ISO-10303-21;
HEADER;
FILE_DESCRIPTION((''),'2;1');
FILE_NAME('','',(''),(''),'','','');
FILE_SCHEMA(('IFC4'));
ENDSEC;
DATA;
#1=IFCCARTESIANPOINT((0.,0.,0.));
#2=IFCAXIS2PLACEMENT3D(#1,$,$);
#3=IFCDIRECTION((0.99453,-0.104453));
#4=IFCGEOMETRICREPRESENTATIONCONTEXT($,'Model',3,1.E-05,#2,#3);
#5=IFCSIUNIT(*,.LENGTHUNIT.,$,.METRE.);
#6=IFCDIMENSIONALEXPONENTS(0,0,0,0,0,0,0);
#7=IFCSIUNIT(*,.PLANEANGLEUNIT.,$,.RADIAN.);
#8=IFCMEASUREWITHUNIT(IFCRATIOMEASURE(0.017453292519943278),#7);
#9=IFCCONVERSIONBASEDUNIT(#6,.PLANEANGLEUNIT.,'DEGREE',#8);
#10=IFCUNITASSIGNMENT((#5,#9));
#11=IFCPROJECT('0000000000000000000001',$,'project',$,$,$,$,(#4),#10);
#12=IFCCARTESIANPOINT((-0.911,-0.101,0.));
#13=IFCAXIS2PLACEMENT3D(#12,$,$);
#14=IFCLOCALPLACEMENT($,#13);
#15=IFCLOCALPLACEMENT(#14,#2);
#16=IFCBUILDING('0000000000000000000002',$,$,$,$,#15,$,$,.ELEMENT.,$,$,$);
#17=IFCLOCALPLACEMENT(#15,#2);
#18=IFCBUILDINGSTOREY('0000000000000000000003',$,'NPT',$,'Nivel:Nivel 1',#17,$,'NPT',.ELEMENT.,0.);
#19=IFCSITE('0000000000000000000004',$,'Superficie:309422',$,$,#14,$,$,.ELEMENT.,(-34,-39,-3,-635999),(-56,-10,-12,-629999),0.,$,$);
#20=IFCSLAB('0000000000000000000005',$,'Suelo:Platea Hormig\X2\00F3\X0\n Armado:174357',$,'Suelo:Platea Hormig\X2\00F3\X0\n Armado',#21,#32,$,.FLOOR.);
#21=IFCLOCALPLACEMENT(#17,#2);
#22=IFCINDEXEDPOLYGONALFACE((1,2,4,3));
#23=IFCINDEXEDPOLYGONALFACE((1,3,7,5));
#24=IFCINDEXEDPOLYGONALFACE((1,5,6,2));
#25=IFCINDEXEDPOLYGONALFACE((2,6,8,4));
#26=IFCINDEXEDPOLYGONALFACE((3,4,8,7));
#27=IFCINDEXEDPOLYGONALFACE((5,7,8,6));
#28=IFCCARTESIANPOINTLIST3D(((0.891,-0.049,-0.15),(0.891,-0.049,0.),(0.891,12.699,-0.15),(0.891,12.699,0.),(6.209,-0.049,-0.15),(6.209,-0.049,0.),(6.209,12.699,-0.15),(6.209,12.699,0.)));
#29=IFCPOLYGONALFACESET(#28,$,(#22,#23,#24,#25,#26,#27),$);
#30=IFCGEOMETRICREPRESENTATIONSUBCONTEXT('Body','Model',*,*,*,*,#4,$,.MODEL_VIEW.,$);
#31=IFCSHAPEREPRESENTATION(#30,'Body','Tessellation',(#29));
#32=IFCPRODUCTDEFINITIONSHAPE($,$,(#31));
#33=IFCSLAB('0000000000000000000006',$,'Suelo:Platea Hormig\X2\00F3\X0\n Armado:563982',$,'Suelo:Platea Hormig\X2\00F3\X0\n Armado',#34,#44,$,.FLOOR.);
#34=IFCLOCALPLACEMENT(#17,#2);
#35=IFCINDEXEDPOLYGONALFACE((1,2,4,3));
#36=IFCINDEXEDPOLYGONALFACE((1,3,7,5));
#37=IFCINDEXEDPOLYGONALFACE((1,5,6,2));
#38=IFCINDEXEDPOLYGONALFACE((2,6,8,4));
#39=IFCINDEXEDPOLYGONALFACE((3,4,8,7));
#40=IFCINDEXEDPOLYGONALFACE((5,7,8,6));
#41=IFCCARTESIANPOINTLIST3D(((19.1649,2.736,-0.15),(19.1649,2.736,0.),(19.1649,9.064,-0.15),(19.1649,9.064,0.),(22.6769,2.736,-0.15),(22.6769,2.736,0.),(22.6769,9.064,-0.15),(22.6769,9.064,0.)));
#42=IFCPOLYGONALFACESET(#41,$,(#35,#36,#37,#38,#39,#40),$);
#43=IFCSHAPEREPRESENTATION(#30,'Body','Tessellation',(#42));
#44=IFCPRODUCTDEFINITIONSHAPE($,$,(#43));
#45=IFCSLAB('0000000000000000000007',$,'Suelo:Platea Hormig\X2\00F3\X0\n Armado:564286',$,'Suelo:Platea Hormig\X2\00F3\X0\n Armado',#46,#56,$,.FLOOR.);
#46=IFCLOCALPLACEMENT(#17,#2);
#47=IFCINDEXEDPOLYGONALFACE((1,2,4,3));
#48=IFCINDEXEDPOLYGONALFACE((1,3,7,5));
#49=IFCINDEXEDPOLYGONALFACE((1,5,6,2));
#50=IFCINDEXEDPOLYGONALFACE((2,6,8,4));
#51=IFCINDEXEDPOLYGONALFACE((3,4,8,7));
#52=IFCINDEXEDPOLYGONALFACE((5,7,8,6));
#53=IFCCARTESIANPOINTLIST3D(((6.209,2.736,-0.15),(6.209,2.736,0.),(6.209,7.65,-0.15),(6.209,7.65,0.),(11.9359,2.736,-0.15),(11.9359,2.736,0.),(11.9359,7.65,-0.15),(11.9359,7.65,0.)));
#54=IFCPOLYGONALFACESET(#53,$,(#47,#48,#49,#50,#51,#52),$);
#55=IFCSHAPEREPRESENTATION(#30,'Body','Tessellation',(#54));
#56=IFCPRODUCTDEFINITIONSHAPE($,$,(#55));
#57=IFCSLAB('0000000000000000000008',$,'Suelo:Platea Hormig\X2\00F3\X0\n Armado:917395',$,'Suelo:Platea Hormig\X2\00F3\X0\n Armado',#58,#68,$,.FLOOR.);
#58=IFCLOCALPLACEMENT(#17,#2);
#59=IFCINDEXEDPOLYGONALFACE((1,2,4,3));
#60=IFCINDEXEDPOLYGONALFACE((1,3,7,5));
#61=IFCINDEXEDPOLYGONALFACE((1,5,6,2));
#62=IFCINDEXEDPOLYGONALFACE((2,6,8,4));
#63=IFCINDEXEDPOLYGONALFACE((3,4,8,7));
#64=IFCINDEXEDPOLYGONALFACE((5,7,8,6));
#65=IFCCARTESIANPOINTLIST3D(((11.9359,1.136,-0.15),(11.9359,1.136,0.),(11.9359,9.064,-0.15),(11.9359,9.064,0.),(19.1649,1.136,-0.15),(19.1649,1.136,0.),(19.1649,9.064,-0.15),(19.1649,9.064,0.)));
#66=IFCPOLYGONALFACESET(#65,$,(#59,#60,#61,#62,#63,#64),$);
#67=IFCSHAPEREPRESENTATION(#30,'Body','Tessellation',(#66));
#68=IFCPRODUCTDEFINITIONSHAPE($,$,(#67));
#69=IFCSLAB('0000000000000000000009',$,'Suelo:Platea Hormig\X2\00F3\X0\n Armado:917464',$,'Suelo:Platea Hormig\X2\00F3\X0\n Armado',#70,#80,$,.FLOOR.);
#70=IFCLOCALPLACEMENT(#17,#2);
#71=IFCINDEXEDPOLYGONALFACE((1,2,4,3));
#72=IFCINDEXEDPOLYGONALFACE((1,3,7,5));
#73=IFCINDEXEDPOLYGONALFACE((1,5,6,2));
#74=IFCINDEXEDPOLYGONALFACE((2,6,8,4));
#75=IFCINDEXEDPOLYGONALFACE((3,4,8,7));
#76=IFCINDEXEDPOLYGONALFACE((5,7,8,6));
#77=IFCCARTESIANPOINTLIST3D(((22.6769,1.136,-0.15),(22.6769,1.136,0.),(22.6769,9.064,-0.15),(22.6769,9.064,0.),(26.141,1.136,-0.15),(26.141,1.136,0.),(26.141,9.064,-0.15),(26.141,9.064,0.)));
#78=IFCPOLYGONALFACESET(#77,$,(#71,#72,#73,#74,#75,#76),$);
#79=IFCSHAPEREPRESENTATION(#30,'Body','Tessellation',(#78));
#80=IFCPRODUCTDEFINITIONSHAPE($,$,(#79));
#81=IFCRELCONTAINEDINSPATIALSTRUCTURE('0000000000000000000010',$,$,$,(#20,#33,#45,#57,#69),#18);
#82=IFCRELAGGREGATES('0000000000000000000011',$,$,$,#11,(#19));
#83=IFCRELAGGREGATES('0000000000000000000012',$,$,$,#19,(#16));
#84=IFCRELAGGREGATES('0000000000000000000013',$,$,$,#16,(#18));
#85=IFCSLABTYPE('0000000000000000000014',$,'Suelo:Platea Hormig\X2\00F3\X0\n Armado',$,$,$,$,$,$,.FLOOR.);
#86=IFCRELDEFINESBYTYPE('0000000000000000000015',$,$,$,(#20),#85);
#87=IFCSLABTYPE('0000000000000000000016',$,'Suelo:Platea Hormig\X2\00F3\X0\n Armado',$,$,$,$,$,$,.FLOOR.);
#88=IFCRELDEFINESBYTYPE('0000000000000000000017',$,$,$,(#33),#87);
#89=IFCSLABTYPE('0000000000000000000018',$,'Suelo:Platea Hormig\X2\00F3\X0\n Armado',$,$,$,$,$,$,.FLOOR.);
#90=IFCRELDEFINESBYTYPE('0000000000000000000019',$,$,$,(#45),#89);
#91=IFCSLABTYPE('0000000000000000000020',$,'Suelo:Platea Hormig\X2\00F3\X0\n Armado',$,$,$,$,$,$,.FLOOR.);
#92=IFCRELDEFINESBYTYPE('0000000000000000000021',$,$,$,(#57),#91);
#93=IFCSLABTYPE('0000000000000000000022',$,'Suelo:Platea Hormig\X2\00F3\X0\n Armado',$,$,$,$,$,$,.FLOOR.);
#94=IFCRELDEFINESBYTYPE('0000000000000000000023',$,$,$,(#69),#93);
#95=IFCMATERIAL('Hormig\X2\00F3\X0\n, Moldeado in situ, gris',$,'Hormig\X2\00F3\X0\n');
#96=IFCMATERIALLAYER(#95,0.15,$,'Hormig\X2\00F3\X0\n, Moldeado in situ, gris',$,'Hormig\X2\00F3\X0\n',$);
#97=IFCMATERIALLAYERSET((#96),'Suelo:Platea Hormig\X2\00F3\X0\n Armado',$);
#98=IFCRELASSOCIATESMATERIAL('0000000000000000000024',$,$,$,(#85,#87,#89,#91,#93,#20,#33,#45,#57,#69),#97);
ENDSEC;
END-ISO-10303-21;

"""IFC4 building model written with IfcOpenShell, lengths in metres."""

from ifc_helpers import new_model, entity, si_unit, converted_unit, direction, frame, frame_2d, origin, origin_2d_with_axis, place, context, subcontext, project, spatial, rectangle, extrude, material, layer, layer_set, layer_usage, type_object, element, save


model = new_model("IFC4")

# Units and contexts
model_context = context("Model", 3, precision=1e-05, world=origin(), true_north=direction((0.99453, -0.104453)))
body_context = subcontext(model_context, "Body", "Model", "MODEL_VIEW")
ifc_project = project(units=[si_unit("LENGTHUNIT", "METRE"), converted_unit("PLANEANGLEUNIT", "DEGREE", entity("IfcRatioMeasure", 0.017453292519943278), si_unit("PLANEANGLEUNIT", "RADIAN"), dimensions=[0, 0, 0, 0, 0, 0, 0])], contexts=[model_context])

# Site, building, storey
site_placement = place(None, frame((-0.911, -0.101, 0.0)))
site = spatial("IfcSite", under=ifc_project, at=site_placement, Name="Superficie:309422", CompositionType="ELEMENT", RefLatitude=(-34, -39, -3, -635999), RefLongitude=(-56, -10, -12, -629999), RefElevation=0.0)
building_placement = place(site_placement, origin())
building = spatial("IfcBuilding", under=site, at=building_placement, CompositionType="ELEMENT")
storey_placement = place(building_placement, origin())
storey = spatial("IfcBuildingStorey", under=building, at=storey_placement, Name="NPT", ObjectType="Nivel:Nivel 1", LongName="NPT", CompositionType="ELEMENT", Elevation=0.0)

# Slabs
ifc_material_1 = material(Name="Hormigón, Moldeado in situ, gris", Category="Hormigón")
ifc_layer = layer(ifc_material_1, 0.15, Name="Hormigón, Moldeado in situ, gris", Category="Hormigón")
ifc_layer_set = layer_set([ifc_layer], Name="Suelo:Platea Hormigón Armado")
ifc_layer_usage_1 = layer_usage(ifc_layer_set, "AXIS3", "POSITIVE", 0.0)
slab_type_1 = type_object("IfcSlabType", Name="Suelo:Platea Hormigón Armado", PredefinedType="FLOOR", material=ifc_layer_set)
slab_1_placement = place(storey_placement, origin())
element("IfcSlab", 1, at=slab_1_placement, inside=storey, type_object=slab_type_1, material=ifc_layer_usage_1, Name="Suelo:Platea Hormigón Armado:174357", ObjectType="Suelo:Platea Hormigón Armado", PredefinedType="FLOOR", context=body_context, shape_type="SweptSolid", body=[
    extrude(rectangle(XDim=12.748, YDim=5.318, at=origin_2d_with_axis()), frame((3.55, 6.325, 0.0), z_axis=(0.0, 0.0, -1.0), x_axis=(0.0, 1.0, 0.0)), (0.0, 0.0, 1.0), 0.15),
])
ifc_layer_usage_2 = layer_usage(ifc_layer_set, "AXIS3", "POSITIVE", 0.0)
slab_type_2 = type_object("IfcSlabType", Name="Suelo:Platea Hormigón Armado", PredefinedType="FLOOR", material=ifc_layer_set)
slab_2_placement = place(storey_placement, origin())
element("IfcSlab", 2, at=slab_2_placement, inside=storey, type_object=slab_type_2, material=ifc_layer_usage_2, Name="Suelo:Platea Hormigón Armado:563982", ObjectType="Suelo:Platea Hormigón Armado", PredefinedType="FLOOR", context=body_context, shape_type="SweptSolid", body=[
    extrude(rectangle(XDim=6.328, YDim=3.512, at=origin_2d_with_axis()), frame((20.9209, 5.9, 0.0), z_axis=(0.0, 0.0, -1.0), x_axis=(0.0, 1.0, 0.0)), (0.0, 0.0, 1.0), 0.15),
])
ifc_layer_usage_3 = layer_usage(ifc_layer_set, "AXIS3", "POSITIVE", 0.0)
slab_type_3 = type_object("IfcSlabType", Name="Suelo:Platea Hormigón Armado", PredefinedType="FLOOR", material=ifc_layer_set)
slab_3_placement = place(storey_placement, origin())
element("IfcSlab", 3, at=slab_3_placement, inside=storey, type_object=slab_type_3, material=ifc_layer_usage_3, Name="Suelo:Platea Hormigón Armado:564286", ObjectType="Suelo:Platea Hormigón Armado", PredefinedType="FLOOR", context=body_context, shape_type="SweptSolid", body=[
    extrude(rectangle(XDim=4.914, YDim=5.7269, at=origin_2d_with_axis()), frame((9.0725, 5.193, 0.0), z_axis=(0.0, 0.0, -1.0), x_axis=(0.0, 1.0, 0.0)), (0.0, 0.0, 1.0), 0.15),
])
ifc_layer_usage_4 = layer_usage(ifc_layer_set, "AXIS3", "POSITIVE", 0.0)
slab_type_4 = type_object("IfcSlabType", Name="Suelo:Platea Hormigón Armado", PredefinedType="FLOOR", material=ifc_layer_set)
slab_4_placement = place(storey_placement, origin())
element("IfcSlab", 4, at=slab_4_placement, inside=storey, type_object=slab_type_4, material=ifc_layer_usage_4, Name="Suelo:Platea Hormigón Armado:917395", ObjectType="Suelo:Platea Hormigón Armado", PredefinedType="FLOOR", context=body_context, shape_type="SweptSolid", body=[
    extrude(rectangle(XDim=7.928, YDim=7.229, at=frame_2d((0.0, 0.0), x_axis=(1.0, 0.0))), frame((15.5504, 5.1, 0.0), z_axis=(0.0, 0.0, -1.0), x_axis=(0.0, 1.0, 0.0)), (0.0, 0.0, 1.0), 0.15),
])
ifc_layer_usage_5 = layer_usage(ifc_layer_set, "AXIS3", "POSITIVE", 0.0)
slab_type_5 = type_object("IfcSlabType", Name="Suelo:Platea Hormigón Armado", PredefinedType="FLOOR", material=ifc_layer_set)
slab_5_placement = place(storey_placement, origin())
element("IfcSlab", 5, at=slab_5_placement, inside=storey, type_object=slab_type_5, material=ifc_layer_usage_5, Name="Suelo:Platea Hormigón Armado:917464", ObjectType="Suelo:Platea Hormigón Armado", PredefinedType="FLOOR", context=body_context, shape_type="SweptSolid", body=[
    extrude(rectangle(XDim=7.928, YDim=3.464, at=frame_2d((0.0, 0.0), x_axis=(1.0, 0.0))), frame((24.409, 5.1, 0.0), z_axis=(0.0, 0.0, -1.0), x_axis=(0.0, 1.0, 0.0)), (0.0, 0.0, 1.0), 0.15),
])

save(model, "model.ifc")
